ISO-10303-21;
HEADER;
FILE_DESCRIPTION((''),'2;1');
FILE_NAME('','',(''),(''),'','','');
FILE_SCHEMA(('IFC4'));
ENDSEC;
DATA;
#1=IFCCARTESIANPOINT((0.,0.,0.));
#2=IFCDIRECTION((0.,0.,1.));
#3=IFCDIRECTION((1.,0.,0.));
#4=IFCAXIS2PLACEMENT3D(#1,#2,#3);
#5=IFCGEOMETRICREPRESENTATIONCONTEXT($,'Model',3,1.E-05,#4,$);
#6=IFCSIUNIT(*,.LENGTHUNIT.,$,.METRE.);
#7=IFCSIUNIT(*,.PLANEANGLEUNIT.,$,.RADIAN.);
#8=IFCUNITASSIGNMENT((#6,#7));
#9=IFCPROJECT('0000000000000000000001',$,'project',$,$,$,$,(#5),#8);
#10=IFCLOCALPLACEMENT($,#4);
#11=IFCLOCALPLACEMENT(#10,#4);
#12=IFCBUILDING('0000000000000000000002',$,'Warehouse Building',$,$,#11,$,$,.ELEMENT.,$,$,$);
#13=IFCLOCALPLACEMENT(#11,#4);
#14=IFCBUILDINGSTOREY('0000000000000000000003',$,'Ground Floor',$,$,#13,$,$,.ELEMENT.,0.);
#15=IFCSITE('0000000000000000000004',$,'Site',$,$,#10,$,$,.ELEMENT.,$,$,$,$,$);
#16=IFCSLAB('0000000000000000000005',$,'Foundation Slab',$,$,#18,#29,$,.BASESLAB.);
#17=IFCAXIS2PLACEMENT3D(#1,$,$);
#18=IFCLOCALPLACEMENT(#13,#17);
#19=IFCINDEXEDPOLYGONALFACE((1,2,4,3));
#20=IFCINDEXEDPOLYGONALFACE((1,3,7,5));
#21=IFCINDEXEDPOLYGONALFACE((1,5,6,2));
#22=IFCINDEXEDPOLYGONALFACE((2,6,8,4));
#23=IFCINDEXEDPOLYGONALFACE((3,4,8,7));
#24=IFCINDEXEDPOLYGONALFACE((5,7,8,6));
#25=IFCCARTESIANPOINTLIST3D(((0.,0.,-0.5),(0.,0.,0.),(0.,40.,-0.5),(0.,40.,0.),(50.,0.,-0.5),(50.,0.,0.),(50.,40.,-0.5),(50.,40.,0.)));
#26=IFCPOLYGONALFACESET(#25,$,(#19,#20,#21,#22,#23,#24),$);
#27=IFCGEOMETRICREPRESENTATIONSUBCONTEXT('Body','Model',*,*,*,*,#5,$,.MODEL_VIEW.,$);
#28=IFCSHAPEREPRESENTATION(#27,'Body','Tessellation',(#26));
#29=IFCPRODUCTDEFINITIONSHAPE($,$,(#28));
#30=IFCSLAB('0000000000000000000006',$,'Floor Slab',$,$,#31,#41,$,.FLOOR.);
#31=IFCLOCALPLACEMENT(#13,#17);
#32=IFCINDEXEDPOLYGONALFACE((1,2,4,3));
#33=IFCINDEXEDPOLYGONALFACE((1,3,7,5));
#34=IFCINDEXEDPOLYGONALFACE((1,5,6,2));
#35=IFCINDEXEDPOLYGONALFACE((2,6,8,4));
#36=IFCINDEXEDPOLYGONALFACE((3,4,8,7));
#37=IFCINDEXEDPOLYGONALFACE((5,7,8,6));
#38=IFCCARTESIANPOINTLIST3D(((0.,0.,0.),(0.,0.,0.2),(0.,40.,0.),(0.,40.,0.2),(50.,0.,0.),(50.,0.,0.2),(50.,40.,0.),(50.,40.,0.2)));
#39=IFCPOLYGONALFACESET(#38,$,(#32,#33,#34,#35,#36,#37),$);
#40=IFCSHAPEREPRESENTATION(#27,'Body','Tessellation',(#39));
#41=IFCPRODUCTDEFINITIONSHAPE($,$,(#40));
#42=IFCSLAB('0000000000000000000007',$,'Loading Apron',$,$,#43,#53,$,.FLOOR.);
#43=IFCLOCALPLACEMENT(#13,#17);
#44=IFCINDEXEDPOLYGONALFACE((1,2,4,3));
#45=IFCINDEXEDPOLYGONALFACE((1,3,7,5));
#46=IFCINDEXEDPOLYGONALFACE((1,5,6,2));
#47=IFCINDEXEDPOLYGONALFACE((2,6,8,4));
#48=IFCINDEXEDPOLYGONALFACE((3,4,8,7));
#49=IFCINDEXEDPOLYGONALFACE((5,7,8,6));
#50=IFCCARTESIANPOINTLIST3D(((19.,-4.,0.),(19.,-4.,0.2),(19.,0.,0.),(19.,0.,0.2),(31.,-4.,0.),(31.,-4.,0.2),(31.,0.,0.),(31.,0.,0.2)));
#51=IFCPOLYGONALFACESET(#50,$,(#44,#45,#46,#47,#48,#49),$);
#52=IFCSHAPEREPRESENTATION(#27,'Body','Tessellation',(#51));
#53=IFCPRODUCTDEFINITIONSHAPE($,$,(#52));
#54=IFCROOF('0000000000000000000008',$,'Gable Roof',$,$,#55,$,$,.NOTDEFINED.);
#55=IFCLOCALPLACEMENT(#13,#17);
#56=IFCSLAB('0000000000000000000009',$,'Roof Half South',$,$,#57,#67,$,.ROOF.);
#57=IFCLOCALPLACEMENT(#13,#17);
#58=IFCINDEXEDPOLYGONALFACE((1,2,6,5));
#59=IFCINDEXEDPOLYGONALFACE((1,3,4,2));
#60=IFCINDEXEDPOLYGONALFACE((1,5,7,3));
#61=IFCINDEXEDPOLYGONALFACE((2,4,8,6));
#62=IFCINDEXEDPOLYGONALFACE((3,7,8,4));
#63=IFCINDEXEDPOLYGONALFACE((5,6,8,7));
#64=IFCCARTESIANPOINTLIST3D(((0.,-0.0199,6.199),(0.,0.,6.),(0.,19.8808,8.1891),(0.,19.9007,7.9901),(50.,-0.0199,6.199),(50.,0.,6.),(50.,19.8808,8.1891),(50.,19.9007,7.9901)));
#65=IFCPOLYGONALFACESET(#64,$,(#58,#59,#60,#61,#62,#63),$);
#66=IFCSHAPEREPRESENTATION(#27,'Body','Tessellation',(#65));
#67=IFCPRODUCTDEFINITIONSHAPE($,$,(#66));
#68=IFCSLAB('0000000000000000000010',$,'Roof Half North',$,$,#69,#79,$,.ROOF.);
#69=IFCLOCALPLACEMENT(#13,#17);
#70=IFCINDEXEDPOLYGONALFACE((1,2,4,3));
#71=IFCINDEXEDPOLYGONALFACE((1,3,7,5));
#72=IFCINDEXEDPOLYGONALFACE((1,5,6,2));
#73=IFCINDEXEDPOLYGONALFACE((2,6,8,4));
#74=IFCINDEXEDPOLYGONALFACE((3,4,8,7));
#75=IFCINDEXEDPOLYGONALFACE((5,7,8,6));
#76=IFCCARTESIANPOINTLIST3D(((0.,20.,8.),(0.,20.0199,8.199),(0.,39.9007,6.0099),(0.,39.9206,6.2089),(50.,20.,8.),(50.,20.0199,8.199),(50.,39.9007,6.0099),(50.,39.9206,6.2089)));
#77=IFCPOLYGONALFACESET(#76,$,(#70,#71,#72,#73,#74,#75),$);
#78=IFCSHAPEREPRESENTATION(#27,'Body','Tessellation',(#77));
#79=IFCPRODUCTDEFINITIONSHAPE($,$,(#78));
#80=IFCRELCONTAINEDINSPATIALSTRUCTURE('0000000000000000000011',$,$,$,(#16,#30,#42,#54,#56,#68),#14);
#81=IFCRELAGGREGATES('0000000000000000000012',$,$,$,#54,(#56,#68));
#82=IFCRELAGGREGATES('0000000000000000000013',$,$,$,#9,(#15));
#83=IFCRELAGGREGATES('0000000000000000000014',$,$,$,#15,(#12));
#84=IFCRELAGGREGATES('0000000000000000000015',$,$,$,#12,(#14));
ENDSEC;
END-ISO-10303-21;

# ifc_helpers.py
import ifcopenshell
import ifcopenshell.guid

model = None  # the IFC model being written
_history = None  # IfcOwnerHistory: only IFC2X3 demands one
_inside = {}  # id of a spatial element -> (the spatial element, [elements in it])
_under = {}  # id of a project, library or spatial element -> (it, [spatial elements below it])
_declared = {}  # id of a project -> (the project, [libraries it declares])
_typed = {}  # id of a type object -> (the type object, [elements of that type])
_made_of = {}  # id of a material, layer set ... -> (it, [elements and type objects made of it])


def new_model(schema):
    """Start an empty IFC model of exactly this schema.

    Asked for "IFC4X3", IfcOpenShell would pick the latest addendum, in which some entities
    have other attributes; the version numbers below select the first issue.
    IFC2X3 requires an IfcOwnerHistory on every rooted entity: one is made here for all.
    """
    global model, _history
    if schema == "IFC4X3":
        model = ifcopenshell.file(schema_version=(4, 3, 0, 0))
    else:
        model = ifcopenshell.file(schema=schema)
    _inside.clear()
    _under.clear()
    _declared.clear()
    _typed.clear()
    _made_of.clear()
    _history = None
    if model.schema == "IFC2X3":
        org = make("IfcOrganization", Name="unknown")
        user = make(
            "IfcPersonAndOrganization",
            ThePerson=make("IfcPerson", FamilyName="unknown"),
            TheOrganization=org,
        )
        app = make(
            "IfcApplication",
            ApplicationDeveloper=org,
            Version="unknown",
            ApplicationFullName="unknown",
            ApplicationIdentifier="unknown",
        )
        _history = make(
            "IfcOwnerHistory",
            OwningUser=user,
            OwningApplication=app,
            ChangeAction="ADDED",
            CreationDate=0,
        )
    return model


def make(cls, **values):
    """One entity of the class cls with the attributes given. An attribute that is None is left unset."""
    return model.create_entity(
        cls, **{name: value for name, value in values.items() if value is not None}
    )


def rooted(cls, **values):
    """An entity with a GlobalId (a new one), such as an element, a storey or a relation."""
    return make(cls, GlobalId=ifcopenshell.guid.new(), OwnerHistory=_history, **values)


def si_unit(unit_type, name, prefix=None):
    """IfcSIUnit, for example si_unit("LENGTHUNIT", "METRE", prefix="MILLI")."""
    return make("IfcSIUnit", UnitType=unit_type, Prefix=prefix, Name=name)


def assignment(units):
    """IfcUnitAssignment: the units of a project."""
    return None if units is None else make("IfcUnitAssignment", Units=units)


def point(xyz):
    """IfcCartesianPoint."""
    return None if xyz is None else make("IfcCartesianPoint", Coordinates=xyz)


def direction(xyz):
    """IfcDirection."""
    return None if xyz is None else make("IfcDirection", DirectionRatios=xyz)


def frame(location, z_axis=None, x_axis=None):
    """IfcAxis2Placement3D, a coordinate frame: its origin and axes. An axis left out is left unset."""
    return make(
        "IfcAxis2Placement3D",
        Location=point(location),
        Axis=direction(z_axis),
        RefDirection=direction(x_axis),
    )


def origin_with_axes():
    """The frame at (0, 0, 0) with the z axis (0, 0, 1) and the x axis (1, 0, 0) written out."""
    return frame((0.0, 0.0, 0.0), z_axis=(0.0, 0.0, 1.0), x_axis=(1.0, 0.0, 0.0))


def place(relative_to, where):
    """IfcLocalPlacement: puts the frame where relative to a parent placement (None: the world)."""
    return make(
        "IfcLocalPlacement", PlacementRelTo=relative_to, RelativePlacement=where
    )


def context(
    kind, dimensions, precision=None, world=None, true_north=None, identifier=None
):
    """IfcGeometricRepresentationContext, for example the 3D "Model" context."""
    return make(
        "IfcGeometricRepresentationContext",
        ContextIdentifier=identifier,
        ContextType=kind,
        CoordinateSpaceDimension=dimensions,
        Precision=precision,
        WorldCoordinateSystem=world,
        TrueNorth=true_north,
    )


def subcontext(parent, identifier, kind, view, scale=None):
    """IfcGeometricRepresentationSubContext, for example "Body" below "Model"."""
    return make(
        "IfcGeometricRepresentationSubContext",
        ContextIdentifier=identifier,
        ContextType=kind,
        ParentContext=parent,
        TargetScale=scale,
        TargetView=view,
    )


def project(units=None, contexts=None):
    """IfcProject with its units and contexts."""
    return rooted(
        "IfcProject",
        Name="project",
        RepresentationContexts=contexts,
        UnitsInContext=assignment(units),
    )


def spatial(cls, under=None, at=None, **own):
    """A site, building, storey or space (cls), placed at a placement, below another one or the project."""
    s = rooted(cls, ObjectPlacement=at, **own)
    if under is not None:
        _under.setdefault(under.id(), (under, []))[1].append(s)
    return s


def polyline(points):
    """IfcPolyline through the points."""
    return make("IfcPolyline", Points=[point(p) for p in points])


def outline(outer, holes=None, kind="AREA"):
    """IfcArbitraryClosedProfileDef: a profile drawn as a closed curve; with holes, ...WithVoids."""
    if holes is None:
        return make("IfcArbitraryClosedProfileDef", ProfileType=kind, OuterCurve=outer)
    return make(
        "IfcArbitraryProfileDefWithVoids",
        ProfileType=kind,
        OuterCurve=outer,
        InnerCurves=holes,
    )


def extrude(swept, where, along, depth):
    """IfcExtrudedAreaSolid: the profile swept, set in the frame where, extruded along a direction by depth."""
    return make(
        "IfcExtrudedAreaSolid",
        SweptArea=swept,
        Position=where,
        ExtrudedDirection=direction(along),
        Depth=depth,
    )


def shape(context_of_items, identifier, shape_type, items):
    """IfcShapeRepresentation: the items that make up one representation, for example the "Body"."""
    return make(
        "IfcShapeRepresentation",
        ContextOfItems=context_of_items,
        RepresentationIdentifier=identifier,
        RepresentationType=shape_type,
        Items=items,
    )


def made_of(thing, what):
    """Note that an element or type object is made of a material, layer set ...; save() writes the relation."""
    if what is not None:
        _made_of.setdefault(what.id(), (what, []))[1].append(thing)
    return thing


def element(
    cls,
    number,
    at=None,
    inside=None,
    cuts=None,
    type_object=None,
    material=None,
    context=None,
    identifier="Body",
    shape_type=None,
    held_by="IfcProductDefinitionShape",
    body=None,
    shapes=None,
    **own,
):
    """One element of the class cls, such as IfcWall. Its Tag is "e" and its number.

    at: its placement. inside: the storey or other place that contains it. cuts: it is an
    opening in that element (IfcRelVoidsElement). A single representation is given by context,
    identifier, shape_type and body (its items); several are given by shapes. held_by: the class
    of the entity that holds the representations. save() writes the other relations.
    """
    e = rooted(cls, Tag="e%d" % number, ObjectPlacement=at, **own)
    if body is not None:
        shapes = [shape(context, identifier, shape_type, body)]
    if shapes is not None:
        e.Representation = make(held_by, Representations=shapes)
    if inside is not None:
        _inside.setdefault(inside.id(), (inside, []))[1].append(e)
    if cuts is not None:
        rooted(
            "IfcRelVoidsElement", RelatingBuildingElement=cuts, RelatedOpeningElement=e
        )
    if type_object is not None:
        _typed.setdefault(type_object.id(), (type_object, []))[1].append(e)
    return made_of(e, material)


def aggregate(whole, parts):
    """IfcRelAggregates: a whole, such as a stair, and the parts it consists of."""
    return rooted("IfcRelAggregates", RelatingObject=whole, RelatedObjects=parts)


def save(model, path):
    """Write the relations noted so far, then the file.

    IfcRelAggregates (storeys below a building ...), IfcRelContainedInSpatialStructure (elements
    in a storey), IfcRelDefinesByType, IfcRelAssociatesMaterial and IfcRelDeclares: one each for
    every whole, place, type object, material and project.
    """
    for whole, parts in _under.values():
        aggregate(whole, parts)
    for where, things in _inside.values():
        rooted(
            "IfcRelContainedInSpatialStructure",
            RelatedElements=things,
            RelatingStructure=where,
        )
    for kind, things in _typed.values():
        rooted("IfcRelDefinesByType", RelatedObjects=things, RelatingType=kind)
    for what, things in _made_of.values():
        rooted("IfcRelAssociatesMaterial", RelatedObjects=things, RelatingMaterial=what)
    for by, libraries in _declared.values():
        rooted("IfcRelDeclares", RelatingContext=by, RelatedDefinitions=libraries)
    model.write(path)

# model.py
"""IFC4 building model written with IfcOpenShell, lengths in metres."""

from ifc_helpers import new_model, si_unit, frame, origin_with_axes, place, context, subcontext, project, spatial, polyline, outline, extrude, element, aggregate, save


model = new_model("IFC4")

# Units and contexts
model_context = context("Model", 3, precision=1e-05, world=origin_with_axes())
body_context = subcontext(model_context, "Body", "Model", "MODEL_VIEW")
ifc_project = project(units=[si_unit("LENGTHUNIT", "METRE"), si_unit("PLANEANGLEUNIT", "RADIAN")], contexts=[model_context])

# Site, building, storey
site_placement = place(None, origin_with_axes())
site = spatial("IfcSite", under=ifc_project, at=site_placement, Name="Site", CompositionType="ELEMENT")
building_placement = place(site_placement, origin_with_axes())
building = spatial("IfcBuilding", under=site, at=building_placement, Name="Warehouse Building", CompositionType="ELEMENT")
placement = place(building_placement, origin_with_axes())
storey = spatial("IfcBuildingStorey", under=building, at=placement, Name="Ground Floor", CompositionType="ELEMENT", Elevation=0.0)

# Slabs
slab_1_placement = place(placement, frame((0.0, 0.0, -0.5), z_axis=(0.0, 0.0, 1.0), x_axis=(1.0, 0.0, 0.0)))
element("IfcSlab", 1, at=slab_1_placement, inside=storey, Name="Foundation Slab", PredefinedType="BASESLAB", context=body_context, shape_type="SweptSolid", body=[
    extrude(outline(polyline([(0.0, 0.0), (50.0, 0.0), (50.0, 40.0), (0.0, 40.0), (0.0, 0.0)])), origin_with_axes(), (0.0, 0.0, 1.0), 0.5),
])
slab_2_placement = place(placement, origin_with_axes())
element("IfcSlab", 2, at=slab_2_placement, inside=storey, Name="Floor Slab", PredefinedType="FLOOR", context=body_context, shape_type="SweptSolid", body=[
    extrude(outline(polyline([(0.0, 0.0), (50.0, 0.0), (50.0, 40.0), (0.0, 40.0), (0.0, 0.0)])), origin_with_axes(), (0.0, 0.0, 1.0), 0.2),
])
slab_3_placement = place(placement, origin_with_axes())
element("IfcSlab", 3, at=slab_3_placement, inside=storey, Name="Loading Apron", PredefinedType="FLOOR", context=body_context, shape_type="SweptSolid", body=[
    extrude(outline(polyline([(19.0, -4.0), (31.0, -4.0), (31.0, 0.0), (19.0, 0.0), (19.0, -4.0)])), origin_with_axes(), (0.0, 0.0, 1.0), 0.2),
])

# Roof, slabs
roof = element("IfcRoof", 4, at=placement, inside=storey, Name="Gable Roof", PredefinedType="NOTDEFINED")
slab_4_placement = place(placement, frame((0.0, 0.0, 6.0), z_axis=(0.0, -0.099504, 0.995037), x_axis=(1.0, 0.0, 0.0)))
slab_4 = element("IfcSlab", 5, at=slab_4_placement, inside=storey, Name="Roof Half South", PredefinedType="ROOF", context=body_context, shape_type="SweptSolid", body=[
    extrude(outline(polyline([(0.0, 0.0), (50.0, 0.0), (50.0, 20.0), (0.0, 20.0), (0.0, 0.0)])), origin_with_axes(), (0.0, 0.0, 1.0), 0.2),
])
slab_5_placement = place(placement, frame((0.0, 20.0, 8.0), z_axis=(0.0, 0.099504, 0.995037), x_axis=(1.0, 0.0, 0.0)))
slab_5 = element("IfcSlab", 6, at=slab_5_placement, inside=storey, Name="Roof Half North", PredefinedType="ROOF", context=body_context, shape_type="SweptSolid", body=[
    extrude(outline(polyline([(0.0, 0.0), (50.0, 0.0), (50.0, 20.0), (0.0, 20.0), (0.0, 0.0)])), origin_with_axes(), (0.0, 0.0, 1.0), 0.2),
])
aggregate(roof, [slab_4, slab_5])

save(model, "model.ifc")
